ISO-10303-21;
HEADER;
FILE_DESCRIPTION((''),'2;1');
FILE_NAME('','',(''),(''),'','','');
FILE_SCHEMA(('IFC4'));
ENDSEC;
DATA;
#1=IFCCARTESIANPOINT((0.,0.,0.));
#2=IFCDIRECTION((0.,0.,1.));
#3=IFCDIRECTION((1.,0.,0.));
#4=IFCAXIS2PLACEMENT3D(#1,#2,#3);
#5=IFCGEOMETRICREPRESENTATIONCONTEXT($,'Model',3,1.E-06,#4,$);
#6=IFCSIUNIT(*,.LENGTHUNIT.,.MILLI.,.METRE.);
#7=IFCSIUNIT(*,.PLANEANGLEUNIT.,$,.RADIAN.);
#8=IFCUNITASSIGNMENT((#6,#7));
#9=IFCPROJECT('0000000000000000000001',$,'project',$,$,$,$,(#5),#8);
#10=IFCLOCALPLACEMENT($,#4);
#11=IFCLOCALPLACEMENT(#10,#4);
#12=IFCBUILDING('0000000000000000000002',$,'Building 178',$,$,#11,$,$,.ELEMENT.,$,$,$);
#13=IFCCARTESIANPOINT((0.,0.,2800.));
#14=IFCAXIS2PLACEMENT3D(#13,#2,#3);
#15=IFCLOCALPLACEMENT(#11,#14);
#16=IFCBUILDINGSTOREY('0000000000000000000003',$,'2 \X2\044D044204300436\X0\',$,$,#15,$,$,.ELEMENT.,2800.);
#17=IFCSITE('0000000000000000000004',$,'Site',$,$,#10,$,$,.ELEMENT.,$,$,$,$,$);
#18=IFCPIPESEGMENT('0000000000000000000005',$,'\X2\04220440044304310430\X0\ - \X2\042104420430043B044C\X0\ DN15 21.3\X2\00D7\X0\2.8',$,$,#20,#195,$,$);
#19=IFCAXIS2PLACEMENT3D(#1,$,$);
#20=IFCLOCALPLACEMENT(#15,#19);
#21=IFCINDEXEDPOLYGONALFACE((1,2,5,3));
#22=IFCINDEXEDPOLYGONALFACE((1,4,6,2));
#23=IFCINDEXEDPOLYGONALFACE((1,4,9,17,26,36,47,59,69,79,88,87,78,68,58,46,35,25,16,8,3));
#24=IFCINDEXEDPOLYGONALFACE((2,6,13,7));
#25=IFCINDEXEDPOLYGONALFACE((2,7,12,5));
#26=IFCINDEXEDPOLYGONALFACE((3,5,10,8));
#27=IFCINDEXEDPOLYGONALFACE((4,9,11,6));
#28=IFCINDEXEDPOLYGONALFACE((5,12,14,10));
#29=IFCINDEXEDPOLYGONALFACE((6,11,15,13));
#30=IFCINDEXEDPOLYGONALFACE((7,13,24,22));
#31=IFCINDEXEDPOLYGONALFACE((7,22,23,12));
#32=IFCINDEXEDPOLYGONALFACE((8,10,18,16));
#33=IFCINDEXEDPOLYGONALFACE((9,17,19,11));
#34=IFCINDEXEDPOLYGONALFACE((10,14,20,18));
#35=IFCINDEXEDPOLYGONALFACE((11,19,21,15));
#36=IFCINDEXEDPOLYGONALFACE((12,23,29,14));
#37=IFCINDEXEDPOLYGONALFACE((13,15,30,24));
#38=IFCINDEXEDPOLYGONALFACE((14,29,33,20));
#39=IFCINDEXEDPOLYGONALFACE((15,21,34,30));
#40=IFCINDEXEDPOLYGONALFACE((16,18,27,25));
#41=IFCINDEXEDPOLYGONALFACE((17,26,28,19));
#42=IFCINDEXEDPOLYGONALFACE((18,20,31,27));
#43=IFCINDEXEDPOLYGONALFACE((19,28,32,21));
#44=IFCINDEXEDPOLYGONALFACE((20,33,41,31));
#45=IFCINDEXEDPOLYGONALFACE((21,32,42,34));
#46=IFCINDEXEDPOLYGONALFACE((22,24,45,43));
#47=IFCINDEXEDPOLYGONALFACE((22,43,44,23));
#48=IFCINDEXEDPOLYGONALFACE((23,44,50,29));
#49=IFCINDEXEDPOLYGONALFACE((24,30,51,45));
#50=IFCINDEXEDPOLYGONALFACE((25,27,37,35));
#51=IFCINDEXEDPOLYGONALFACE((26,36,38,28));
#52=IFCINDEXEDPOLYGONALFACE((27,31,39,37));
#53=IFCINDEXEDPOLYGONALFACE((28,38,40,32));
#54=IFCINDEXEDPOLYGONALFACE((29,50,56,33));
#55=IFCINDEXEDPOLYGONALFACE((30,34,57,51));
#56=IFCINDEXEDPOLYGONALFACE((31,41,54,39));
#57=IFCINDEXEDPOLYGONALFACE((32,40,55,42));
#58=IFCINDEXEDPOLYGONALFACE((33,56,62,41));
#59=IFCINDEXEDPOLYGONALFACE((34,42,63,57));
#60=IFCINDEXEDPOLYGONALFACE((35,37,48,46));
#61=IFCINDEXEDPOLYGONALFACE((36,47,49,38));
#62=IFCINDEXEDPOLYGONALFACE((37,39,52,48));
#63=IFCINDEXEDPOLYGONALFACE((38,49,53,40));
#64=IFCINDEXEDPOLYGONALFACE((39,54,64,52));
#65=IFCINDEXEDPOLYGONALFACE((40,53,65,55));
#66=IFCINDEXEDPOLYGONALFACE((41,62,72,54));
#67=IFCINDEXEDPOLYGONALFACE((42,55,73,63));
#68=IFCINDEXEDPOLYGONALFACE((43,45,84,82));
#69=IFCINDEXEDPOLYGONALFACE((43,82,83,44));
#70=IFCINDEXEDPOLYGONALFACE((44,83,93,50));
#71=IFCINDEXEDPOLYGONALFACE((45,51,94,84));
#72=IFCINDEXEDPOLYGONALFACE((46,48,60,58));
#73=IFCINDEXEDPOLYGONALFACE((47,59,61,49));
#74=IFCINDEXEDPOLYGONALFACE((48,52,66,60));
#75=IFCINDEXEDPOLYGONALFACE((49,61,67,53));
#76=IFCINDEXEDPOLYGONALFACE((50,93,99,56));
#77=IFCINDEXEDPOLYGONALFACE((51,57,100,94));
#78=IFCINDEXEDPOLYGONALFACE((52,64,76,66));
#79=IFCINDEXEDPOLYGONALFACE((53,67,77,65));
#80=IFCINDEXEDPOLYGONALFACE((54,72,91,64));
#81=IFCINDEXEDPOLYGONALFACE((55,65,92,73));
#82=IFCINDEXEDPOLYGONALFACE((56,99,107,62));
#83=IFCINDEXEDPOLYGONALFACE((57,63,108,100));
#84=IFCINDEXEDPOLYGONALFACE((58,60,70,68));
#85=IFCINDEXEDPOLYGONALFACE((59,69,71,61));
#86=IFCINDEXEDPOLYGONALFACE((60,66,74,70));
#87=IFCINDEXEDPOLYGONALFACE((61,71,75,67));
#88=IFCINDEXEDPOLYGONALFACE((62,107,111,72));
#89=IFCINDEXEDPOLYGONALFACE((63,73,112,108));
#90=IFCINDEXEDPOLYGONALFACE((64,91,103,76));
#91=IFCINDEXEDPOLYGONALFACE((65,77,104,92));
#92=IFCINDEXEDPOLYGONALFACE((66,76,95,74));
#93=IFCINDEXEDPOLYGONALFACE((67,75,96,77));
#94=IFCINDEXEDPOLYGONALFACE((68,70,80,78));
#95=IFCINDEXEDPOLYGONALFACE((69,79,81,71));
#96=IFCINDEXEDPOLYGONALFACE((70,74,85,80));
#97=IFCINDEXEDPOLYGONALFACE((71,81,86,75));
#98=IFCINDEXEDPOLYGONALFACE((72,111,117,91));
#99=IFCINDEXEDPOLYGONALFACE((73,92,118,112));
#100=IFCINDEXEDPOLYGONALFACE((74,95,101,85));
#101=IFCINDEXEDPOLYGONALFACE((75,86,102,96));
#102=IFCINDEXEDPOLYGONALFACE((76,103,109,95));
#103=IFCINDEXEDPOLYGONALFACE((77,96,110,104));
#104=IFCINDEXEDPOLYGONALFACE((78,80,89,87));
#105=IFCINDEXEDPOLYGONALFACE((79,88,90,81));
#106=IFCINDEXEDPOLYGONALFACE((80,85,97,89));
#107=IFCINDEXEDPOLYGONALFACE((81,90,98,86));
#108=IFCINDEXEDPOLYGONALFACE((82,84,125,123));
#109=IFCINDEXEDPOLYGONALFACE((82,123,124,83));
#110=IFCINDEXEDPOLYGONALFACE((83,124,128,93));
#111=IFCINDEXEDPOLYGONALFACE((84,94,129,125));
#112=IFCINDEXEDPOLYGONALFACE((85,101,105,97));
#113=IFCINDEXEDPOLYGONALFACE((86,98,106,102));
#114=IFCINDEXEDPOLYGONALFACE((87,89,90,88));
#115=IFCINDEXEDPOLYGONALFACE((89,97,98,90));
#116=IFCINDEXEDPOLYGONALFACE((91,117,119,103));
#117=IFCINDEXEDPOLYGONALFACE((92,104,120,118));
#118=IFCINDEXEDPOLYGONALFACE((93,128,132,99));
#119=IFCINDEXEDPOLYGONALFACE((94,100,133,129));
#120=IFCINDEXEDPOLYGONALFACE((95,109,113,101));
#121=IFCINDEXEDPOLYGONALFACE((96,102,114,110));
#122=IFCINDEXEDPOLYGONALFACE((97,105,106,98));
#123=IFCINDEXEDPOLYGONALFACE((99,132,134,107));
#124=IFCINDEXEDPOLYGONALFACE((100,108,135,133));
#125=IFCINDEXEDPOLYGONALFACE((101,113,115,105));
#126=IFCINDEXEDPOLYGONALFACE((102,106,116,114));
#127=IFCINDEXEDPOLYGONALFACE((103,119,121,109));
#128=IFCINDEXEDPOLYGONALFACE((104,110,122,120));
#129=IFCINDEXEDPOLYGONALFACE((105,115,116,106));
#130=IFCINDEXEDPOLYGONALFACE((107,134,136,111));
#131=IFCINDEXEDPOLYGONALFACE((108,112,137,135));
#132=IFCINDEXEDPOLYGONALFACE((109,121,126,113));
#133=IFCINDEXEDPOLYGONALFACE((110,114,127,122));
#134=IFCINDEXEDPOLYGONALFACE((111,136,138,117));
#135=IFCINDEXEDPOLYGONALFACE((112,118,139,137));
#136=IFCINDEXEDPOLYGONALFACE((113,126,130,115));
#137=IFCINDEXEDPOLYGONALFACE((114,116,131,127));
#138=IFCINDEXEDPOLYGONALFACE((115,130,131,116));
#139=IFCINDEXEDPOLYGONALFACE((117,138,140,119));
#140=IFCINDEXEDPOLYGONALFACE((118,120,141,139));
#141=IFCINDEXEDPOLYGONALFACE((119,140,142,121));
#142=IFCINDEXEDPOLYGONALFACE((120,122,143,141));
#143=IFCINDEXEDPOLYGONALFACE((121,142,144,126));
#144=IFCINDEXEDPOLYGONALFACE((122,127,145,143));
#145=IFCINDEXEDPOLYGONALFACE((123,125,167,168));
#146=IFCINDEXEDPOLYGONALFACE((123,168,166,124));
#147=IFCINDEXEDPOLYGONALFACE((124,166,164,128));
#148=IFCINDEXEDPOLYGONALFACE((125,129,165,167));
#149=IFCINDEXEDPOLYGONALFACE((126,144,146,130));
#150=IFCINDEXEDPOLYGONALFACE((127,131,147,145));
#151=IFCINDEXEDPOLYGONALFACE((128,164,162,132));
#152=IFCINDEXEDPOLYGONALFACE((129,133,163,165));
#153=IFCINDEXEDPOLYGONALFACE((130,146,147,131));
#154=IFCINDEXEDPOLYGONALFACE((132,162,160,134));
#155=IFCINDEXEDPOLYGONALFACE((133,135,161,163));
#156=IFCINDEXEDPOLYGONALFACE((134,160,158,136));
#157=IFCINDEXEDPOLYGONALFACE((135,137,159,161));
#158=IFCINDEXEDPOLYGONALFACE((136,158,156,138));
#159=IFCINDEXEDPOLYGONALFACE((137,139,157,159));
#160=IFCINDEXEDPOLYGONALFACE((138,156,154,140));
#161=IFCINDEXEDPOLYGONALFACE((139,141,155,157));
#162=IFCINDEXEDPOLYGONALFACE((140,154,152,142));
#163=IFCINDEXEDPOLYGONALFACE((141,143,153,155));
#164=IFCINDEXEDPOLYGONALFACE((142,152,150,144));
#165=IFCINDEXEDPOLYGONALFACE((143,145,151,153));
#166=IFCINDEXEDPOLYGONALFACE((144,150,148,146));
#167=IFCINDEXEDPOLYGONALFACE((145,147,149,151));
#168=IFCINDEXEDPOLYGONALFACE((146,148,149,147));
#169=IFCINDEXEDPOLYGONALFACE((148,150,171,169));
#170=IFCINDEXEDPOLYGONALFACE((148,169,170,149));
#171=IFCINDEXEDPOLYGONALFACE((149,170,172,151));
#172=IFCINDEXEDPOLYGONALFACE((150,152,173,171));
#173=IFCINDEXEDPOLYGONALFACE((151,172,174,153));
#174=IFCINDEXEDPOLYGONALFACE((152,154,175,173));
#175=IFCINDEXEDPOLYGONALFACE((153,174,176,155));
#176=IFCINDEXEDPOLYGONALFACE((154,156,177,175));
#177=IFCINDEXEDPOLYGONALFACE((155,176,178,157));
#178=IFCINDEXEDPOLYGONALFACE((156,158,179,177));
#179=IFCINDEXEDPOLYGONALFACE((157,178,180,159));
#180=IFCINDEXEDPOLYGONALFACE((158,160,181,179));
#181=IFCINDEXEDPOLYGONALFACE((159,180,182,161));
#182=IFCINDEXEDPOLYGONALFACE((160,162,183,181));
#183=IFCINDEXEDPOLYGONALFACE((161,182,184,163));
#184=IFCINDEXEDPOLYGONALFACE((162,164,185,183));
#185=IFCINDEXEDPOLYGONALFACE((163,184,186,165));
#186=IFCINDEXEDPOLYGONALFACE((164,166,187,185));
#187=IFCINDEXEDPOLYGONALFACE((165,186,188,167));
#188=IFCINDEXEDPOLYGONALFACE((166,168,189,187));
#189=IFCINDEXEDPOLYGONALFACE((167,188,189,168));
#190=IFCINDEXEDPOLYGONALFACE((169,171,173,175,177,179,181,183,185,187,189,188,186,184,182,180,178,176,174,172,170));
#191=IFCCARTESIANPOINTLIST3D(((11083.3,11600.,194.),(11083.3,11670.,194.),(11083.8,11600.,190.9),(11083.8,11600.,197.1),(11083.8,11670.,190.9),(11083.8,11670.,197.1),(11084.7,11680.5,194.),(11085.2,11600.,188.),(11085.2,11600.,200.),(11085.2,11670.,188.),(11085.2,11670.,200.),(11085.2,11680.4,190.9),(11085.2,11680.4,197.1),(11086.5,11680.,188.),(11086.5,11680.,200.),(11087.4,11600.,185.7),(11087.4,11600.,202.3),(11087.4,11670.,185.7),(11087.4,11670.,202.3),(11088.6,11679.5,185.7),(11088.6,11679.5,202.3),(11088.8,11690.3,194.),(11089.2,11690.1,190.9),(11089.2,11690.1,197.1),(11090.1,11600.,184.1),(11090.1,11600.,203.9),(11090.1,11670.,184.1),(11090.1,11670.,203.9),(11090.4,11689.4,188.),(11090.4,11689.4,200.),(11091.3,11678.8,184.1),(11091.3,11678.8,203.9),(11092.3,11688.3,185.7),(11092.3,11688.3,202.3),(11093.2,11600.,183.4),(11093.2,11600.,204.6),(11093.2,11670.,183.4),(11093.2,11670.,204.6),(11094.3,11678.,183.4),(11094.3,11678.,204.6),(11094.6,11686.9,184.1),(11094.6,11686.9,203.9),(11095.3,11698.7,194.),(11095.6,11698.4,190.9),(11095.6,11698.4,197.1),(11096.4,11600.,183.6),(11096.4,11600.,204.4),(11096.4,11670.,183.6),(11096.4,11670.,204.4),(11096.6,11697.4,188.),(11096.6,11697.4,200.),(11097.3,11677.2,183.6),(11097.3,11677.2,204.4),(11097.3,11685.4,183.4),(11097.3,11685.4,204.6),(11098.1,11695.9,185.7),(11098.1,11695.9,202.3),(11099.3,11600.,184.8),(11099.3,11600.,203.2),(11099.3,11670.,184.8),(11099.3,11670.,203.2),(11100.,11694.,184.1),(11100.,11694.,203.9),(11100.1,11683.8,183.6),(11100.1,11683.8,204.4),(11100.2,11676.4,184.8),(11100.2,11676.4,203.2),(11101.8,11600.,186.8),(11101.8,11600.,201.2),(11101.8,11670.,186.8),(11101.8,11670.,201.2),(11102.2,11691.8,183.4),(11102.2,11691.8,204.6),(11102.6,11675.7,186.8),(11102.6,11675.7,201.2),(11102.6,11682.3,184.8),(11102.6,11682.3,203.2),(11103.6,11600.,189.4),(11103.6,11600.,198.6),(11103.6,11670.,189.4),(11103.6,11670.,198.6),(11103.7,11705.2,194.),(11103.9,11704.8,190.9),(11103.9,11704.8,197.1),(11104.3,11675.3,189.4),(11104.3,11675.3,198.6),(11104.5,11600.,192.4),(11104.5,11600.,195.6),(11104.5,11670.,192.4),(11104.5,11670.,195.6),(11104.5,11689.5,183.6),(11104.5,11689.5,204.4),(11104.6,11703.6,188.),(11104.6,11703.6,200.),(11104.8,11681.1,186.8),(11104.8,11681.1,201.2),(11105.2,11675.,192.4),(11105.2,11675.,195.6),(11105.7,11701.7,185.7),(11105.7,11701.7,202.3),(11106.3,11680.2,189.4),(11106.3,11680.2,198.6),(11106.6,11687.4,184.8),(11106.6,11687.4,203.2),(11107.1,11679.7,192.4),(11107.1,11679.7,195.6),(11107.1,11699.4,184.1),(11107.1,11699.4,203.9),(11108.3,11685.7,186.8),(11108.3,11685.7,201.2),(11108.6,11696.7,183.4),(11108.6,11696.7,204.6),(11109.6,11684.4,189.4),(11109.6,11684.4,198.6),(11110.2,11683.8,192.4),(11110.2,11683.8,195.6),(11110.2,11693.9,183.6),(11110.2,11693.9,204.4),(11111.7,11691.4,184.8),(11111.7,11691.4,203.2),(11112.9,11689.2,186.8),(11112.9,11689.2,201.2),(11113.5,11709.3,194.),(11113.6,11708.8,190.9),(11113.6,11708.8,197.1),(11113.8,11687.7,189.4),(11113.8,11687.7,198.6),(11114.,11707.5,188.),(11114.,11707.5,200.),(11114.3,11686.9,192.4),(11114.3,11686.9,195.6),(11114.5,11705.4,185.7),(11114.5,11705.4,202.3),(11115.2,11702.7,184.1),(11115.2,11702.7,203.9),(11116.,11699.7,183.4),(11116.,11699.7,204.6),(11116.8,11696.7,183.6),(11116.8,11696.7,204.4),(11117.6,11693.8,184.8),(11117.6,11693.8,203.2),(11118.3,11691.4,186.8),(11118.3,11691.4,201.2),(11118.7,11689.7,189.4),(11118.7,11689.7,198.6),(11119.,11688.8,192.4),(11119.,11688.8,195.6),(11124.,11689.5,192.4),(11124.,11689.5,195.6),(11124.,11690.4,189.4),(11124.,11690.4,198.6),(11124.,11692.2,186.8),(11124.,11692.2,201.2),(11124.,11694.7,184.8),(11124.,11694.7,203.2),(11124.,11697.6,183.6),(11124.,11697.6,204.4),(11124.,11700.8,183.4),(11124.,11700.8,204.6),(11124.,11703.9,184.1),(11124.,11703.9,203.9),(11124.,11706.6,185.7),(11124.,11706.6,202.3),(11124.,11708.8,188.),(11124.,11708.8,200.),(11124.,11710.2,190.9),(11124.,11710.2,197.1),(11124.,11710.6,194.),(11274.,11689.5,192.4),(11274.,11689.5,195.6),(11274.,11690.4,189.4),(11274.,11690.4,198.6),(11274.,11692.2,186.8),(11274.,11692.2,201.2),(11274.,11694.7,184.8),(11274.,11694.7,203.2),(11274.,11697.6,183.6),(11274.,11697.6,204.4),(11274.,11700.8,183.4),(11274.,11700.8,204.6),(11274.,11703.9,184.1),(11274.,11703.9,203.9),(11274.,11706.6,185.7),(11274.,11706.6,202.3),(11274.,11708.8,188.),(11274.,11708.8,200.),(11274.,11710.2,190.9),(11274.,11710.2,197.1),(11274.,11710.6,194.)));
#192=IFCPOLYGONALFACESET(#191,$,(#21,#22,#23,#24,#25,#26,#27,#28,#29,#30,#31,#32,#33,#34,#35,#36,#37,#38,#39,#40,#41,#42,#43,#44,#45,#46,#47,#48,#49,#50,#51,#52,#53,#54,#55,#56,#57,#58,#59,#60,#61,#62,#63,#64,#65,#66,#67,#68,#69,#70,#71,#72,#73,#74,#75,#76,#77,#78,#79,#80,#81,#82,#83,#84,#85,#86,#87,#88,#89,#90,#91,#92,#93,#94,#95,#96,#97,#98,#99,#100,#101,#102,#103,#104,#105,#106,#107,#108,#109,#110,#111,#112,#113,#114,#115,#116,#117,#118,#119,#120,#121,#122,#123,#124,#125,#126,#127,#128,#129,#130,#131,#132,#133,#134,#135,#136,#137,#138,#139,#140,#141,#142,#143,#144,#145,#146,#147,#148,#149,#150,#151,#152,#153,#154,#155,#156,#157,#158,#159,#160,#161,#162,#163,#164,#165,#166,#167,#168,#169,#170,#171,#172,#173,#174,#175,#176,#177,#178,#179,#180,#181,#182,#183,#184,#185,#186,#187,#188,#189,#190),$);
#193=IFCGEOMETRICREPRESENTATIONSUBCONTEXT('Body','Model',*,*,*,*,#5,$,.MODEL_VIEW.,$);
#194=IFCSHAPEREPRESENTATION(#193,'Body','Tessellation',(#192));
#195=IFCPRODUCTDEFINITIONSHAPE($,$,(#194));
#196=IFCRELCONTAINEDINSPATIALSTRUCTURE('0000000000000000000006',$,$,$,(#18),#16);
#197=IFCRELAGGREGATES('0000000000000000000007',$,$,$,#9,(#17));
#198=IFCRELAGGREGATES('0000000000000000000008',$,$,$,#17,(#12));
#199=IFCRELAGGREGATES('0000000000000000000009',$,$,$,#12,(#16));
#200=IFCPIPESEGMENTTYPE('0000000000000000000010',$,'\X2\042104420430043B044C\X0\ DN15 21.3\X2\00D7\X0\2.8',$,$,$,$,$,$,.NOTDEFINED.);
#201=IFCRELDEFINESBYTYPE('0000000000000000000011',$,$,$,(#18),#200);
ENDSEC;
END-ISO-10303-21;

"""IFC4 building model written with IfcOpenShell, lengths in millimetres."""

from ifc_helpers import new_model, entity, si_unit, frame, origin_with_axes, place, context, subcontext, project, spatial, source, transform, mapped, type_object, element, save


model = new_model("IFC4")

# Units and contexts
model_context = context("Model", 3, precision=1e-06, world=origin_with_axes())
body_context = subcontext(model_context, "Body", "Model", "MODEL_VIEW")
ifc_project = project(units=[si_unit("LENGTHUNIT", "METRE", prefix="MILLI"), si_unit("PLANEANGLEUNIT", "RADIAN")], contexts=[model_context])

# Site, building, storey
site_placement = place(None, origin_with_axes())
site = spatial("IfcSite", under=ifc_project, at=site_placement, Name="Site", CompositionType="ELEMENT")
building_placement = place(site_placement, origin_with_axes())
building = spatial("IfcBuilding", under=site, at=building_placement, Name="Building 178", CompositionType="ELEMENT")
storey_placement = place(building_placement, frame((0.0, 0.0, 2800.0), z_axis=(0.0, 0.0, 1.0), x_axis=(1.0, 0.0, 0.0)))
storey = spatial("IfcBuildingStorey", under=building, at=storey_placement, Name="2 этаж", CompositionType="ELEMENT", Elevation=2800.0)

# Pipe segment
pipe_segment_type = type_object("IfcPipeSegmentType", Name="Сталь DN15 21.3×2.8", PredefinedType="NOTDEFINED")
shared_shape_1 = source(origin_with_axes(), body_context, "Body", "AdvancedSweptSolid", [
    entity("IfcSweptDiskSolid", entity("IfcIndexedPolyCurve", entity("IfcCartesianPointList3D", [[0.0, 0.0, 0.0], [0.0, 0.0, -70.0], [8.8, 0.0, -91.2], [30.0, 0.0, -100.0], [180.0, 0.0, -100.0]]), [entity("IfcLineIndex", [1, 2]), entity("IfcArcIndex", [2, 3, 4]), entity("IfcLineIndex", [4, 5])]), 10.7),
])
for number, where, z_axis, x_axis, name in (
    (1, (11094.0, 11600.0, 194.0), (0.0, -1.0, 0.0), (1.0, 0.0, 0.0), "Труба - Сталь DN15 21.3×2.8"),
):
    element("IfcPipeSegment", number, at=place(storey_placement, frame(where, z_axis=z_axis, x_axis=x_axis)), inside=storey, type_object=pipe_segment_type, Name=name, context=body_context, shape_type="MappedRepresentation", body=[
        mapped(shared_shape_1, transform((0.0, 0.0, 0.0), x_axis=(1.0, 0.0, 0.0), y_axis=(0.0, 1.0, 0.0), z_axis=(0.0, 0.0, 1.0), scale=1.0)),
    ])

save(model, "model.ifc")
